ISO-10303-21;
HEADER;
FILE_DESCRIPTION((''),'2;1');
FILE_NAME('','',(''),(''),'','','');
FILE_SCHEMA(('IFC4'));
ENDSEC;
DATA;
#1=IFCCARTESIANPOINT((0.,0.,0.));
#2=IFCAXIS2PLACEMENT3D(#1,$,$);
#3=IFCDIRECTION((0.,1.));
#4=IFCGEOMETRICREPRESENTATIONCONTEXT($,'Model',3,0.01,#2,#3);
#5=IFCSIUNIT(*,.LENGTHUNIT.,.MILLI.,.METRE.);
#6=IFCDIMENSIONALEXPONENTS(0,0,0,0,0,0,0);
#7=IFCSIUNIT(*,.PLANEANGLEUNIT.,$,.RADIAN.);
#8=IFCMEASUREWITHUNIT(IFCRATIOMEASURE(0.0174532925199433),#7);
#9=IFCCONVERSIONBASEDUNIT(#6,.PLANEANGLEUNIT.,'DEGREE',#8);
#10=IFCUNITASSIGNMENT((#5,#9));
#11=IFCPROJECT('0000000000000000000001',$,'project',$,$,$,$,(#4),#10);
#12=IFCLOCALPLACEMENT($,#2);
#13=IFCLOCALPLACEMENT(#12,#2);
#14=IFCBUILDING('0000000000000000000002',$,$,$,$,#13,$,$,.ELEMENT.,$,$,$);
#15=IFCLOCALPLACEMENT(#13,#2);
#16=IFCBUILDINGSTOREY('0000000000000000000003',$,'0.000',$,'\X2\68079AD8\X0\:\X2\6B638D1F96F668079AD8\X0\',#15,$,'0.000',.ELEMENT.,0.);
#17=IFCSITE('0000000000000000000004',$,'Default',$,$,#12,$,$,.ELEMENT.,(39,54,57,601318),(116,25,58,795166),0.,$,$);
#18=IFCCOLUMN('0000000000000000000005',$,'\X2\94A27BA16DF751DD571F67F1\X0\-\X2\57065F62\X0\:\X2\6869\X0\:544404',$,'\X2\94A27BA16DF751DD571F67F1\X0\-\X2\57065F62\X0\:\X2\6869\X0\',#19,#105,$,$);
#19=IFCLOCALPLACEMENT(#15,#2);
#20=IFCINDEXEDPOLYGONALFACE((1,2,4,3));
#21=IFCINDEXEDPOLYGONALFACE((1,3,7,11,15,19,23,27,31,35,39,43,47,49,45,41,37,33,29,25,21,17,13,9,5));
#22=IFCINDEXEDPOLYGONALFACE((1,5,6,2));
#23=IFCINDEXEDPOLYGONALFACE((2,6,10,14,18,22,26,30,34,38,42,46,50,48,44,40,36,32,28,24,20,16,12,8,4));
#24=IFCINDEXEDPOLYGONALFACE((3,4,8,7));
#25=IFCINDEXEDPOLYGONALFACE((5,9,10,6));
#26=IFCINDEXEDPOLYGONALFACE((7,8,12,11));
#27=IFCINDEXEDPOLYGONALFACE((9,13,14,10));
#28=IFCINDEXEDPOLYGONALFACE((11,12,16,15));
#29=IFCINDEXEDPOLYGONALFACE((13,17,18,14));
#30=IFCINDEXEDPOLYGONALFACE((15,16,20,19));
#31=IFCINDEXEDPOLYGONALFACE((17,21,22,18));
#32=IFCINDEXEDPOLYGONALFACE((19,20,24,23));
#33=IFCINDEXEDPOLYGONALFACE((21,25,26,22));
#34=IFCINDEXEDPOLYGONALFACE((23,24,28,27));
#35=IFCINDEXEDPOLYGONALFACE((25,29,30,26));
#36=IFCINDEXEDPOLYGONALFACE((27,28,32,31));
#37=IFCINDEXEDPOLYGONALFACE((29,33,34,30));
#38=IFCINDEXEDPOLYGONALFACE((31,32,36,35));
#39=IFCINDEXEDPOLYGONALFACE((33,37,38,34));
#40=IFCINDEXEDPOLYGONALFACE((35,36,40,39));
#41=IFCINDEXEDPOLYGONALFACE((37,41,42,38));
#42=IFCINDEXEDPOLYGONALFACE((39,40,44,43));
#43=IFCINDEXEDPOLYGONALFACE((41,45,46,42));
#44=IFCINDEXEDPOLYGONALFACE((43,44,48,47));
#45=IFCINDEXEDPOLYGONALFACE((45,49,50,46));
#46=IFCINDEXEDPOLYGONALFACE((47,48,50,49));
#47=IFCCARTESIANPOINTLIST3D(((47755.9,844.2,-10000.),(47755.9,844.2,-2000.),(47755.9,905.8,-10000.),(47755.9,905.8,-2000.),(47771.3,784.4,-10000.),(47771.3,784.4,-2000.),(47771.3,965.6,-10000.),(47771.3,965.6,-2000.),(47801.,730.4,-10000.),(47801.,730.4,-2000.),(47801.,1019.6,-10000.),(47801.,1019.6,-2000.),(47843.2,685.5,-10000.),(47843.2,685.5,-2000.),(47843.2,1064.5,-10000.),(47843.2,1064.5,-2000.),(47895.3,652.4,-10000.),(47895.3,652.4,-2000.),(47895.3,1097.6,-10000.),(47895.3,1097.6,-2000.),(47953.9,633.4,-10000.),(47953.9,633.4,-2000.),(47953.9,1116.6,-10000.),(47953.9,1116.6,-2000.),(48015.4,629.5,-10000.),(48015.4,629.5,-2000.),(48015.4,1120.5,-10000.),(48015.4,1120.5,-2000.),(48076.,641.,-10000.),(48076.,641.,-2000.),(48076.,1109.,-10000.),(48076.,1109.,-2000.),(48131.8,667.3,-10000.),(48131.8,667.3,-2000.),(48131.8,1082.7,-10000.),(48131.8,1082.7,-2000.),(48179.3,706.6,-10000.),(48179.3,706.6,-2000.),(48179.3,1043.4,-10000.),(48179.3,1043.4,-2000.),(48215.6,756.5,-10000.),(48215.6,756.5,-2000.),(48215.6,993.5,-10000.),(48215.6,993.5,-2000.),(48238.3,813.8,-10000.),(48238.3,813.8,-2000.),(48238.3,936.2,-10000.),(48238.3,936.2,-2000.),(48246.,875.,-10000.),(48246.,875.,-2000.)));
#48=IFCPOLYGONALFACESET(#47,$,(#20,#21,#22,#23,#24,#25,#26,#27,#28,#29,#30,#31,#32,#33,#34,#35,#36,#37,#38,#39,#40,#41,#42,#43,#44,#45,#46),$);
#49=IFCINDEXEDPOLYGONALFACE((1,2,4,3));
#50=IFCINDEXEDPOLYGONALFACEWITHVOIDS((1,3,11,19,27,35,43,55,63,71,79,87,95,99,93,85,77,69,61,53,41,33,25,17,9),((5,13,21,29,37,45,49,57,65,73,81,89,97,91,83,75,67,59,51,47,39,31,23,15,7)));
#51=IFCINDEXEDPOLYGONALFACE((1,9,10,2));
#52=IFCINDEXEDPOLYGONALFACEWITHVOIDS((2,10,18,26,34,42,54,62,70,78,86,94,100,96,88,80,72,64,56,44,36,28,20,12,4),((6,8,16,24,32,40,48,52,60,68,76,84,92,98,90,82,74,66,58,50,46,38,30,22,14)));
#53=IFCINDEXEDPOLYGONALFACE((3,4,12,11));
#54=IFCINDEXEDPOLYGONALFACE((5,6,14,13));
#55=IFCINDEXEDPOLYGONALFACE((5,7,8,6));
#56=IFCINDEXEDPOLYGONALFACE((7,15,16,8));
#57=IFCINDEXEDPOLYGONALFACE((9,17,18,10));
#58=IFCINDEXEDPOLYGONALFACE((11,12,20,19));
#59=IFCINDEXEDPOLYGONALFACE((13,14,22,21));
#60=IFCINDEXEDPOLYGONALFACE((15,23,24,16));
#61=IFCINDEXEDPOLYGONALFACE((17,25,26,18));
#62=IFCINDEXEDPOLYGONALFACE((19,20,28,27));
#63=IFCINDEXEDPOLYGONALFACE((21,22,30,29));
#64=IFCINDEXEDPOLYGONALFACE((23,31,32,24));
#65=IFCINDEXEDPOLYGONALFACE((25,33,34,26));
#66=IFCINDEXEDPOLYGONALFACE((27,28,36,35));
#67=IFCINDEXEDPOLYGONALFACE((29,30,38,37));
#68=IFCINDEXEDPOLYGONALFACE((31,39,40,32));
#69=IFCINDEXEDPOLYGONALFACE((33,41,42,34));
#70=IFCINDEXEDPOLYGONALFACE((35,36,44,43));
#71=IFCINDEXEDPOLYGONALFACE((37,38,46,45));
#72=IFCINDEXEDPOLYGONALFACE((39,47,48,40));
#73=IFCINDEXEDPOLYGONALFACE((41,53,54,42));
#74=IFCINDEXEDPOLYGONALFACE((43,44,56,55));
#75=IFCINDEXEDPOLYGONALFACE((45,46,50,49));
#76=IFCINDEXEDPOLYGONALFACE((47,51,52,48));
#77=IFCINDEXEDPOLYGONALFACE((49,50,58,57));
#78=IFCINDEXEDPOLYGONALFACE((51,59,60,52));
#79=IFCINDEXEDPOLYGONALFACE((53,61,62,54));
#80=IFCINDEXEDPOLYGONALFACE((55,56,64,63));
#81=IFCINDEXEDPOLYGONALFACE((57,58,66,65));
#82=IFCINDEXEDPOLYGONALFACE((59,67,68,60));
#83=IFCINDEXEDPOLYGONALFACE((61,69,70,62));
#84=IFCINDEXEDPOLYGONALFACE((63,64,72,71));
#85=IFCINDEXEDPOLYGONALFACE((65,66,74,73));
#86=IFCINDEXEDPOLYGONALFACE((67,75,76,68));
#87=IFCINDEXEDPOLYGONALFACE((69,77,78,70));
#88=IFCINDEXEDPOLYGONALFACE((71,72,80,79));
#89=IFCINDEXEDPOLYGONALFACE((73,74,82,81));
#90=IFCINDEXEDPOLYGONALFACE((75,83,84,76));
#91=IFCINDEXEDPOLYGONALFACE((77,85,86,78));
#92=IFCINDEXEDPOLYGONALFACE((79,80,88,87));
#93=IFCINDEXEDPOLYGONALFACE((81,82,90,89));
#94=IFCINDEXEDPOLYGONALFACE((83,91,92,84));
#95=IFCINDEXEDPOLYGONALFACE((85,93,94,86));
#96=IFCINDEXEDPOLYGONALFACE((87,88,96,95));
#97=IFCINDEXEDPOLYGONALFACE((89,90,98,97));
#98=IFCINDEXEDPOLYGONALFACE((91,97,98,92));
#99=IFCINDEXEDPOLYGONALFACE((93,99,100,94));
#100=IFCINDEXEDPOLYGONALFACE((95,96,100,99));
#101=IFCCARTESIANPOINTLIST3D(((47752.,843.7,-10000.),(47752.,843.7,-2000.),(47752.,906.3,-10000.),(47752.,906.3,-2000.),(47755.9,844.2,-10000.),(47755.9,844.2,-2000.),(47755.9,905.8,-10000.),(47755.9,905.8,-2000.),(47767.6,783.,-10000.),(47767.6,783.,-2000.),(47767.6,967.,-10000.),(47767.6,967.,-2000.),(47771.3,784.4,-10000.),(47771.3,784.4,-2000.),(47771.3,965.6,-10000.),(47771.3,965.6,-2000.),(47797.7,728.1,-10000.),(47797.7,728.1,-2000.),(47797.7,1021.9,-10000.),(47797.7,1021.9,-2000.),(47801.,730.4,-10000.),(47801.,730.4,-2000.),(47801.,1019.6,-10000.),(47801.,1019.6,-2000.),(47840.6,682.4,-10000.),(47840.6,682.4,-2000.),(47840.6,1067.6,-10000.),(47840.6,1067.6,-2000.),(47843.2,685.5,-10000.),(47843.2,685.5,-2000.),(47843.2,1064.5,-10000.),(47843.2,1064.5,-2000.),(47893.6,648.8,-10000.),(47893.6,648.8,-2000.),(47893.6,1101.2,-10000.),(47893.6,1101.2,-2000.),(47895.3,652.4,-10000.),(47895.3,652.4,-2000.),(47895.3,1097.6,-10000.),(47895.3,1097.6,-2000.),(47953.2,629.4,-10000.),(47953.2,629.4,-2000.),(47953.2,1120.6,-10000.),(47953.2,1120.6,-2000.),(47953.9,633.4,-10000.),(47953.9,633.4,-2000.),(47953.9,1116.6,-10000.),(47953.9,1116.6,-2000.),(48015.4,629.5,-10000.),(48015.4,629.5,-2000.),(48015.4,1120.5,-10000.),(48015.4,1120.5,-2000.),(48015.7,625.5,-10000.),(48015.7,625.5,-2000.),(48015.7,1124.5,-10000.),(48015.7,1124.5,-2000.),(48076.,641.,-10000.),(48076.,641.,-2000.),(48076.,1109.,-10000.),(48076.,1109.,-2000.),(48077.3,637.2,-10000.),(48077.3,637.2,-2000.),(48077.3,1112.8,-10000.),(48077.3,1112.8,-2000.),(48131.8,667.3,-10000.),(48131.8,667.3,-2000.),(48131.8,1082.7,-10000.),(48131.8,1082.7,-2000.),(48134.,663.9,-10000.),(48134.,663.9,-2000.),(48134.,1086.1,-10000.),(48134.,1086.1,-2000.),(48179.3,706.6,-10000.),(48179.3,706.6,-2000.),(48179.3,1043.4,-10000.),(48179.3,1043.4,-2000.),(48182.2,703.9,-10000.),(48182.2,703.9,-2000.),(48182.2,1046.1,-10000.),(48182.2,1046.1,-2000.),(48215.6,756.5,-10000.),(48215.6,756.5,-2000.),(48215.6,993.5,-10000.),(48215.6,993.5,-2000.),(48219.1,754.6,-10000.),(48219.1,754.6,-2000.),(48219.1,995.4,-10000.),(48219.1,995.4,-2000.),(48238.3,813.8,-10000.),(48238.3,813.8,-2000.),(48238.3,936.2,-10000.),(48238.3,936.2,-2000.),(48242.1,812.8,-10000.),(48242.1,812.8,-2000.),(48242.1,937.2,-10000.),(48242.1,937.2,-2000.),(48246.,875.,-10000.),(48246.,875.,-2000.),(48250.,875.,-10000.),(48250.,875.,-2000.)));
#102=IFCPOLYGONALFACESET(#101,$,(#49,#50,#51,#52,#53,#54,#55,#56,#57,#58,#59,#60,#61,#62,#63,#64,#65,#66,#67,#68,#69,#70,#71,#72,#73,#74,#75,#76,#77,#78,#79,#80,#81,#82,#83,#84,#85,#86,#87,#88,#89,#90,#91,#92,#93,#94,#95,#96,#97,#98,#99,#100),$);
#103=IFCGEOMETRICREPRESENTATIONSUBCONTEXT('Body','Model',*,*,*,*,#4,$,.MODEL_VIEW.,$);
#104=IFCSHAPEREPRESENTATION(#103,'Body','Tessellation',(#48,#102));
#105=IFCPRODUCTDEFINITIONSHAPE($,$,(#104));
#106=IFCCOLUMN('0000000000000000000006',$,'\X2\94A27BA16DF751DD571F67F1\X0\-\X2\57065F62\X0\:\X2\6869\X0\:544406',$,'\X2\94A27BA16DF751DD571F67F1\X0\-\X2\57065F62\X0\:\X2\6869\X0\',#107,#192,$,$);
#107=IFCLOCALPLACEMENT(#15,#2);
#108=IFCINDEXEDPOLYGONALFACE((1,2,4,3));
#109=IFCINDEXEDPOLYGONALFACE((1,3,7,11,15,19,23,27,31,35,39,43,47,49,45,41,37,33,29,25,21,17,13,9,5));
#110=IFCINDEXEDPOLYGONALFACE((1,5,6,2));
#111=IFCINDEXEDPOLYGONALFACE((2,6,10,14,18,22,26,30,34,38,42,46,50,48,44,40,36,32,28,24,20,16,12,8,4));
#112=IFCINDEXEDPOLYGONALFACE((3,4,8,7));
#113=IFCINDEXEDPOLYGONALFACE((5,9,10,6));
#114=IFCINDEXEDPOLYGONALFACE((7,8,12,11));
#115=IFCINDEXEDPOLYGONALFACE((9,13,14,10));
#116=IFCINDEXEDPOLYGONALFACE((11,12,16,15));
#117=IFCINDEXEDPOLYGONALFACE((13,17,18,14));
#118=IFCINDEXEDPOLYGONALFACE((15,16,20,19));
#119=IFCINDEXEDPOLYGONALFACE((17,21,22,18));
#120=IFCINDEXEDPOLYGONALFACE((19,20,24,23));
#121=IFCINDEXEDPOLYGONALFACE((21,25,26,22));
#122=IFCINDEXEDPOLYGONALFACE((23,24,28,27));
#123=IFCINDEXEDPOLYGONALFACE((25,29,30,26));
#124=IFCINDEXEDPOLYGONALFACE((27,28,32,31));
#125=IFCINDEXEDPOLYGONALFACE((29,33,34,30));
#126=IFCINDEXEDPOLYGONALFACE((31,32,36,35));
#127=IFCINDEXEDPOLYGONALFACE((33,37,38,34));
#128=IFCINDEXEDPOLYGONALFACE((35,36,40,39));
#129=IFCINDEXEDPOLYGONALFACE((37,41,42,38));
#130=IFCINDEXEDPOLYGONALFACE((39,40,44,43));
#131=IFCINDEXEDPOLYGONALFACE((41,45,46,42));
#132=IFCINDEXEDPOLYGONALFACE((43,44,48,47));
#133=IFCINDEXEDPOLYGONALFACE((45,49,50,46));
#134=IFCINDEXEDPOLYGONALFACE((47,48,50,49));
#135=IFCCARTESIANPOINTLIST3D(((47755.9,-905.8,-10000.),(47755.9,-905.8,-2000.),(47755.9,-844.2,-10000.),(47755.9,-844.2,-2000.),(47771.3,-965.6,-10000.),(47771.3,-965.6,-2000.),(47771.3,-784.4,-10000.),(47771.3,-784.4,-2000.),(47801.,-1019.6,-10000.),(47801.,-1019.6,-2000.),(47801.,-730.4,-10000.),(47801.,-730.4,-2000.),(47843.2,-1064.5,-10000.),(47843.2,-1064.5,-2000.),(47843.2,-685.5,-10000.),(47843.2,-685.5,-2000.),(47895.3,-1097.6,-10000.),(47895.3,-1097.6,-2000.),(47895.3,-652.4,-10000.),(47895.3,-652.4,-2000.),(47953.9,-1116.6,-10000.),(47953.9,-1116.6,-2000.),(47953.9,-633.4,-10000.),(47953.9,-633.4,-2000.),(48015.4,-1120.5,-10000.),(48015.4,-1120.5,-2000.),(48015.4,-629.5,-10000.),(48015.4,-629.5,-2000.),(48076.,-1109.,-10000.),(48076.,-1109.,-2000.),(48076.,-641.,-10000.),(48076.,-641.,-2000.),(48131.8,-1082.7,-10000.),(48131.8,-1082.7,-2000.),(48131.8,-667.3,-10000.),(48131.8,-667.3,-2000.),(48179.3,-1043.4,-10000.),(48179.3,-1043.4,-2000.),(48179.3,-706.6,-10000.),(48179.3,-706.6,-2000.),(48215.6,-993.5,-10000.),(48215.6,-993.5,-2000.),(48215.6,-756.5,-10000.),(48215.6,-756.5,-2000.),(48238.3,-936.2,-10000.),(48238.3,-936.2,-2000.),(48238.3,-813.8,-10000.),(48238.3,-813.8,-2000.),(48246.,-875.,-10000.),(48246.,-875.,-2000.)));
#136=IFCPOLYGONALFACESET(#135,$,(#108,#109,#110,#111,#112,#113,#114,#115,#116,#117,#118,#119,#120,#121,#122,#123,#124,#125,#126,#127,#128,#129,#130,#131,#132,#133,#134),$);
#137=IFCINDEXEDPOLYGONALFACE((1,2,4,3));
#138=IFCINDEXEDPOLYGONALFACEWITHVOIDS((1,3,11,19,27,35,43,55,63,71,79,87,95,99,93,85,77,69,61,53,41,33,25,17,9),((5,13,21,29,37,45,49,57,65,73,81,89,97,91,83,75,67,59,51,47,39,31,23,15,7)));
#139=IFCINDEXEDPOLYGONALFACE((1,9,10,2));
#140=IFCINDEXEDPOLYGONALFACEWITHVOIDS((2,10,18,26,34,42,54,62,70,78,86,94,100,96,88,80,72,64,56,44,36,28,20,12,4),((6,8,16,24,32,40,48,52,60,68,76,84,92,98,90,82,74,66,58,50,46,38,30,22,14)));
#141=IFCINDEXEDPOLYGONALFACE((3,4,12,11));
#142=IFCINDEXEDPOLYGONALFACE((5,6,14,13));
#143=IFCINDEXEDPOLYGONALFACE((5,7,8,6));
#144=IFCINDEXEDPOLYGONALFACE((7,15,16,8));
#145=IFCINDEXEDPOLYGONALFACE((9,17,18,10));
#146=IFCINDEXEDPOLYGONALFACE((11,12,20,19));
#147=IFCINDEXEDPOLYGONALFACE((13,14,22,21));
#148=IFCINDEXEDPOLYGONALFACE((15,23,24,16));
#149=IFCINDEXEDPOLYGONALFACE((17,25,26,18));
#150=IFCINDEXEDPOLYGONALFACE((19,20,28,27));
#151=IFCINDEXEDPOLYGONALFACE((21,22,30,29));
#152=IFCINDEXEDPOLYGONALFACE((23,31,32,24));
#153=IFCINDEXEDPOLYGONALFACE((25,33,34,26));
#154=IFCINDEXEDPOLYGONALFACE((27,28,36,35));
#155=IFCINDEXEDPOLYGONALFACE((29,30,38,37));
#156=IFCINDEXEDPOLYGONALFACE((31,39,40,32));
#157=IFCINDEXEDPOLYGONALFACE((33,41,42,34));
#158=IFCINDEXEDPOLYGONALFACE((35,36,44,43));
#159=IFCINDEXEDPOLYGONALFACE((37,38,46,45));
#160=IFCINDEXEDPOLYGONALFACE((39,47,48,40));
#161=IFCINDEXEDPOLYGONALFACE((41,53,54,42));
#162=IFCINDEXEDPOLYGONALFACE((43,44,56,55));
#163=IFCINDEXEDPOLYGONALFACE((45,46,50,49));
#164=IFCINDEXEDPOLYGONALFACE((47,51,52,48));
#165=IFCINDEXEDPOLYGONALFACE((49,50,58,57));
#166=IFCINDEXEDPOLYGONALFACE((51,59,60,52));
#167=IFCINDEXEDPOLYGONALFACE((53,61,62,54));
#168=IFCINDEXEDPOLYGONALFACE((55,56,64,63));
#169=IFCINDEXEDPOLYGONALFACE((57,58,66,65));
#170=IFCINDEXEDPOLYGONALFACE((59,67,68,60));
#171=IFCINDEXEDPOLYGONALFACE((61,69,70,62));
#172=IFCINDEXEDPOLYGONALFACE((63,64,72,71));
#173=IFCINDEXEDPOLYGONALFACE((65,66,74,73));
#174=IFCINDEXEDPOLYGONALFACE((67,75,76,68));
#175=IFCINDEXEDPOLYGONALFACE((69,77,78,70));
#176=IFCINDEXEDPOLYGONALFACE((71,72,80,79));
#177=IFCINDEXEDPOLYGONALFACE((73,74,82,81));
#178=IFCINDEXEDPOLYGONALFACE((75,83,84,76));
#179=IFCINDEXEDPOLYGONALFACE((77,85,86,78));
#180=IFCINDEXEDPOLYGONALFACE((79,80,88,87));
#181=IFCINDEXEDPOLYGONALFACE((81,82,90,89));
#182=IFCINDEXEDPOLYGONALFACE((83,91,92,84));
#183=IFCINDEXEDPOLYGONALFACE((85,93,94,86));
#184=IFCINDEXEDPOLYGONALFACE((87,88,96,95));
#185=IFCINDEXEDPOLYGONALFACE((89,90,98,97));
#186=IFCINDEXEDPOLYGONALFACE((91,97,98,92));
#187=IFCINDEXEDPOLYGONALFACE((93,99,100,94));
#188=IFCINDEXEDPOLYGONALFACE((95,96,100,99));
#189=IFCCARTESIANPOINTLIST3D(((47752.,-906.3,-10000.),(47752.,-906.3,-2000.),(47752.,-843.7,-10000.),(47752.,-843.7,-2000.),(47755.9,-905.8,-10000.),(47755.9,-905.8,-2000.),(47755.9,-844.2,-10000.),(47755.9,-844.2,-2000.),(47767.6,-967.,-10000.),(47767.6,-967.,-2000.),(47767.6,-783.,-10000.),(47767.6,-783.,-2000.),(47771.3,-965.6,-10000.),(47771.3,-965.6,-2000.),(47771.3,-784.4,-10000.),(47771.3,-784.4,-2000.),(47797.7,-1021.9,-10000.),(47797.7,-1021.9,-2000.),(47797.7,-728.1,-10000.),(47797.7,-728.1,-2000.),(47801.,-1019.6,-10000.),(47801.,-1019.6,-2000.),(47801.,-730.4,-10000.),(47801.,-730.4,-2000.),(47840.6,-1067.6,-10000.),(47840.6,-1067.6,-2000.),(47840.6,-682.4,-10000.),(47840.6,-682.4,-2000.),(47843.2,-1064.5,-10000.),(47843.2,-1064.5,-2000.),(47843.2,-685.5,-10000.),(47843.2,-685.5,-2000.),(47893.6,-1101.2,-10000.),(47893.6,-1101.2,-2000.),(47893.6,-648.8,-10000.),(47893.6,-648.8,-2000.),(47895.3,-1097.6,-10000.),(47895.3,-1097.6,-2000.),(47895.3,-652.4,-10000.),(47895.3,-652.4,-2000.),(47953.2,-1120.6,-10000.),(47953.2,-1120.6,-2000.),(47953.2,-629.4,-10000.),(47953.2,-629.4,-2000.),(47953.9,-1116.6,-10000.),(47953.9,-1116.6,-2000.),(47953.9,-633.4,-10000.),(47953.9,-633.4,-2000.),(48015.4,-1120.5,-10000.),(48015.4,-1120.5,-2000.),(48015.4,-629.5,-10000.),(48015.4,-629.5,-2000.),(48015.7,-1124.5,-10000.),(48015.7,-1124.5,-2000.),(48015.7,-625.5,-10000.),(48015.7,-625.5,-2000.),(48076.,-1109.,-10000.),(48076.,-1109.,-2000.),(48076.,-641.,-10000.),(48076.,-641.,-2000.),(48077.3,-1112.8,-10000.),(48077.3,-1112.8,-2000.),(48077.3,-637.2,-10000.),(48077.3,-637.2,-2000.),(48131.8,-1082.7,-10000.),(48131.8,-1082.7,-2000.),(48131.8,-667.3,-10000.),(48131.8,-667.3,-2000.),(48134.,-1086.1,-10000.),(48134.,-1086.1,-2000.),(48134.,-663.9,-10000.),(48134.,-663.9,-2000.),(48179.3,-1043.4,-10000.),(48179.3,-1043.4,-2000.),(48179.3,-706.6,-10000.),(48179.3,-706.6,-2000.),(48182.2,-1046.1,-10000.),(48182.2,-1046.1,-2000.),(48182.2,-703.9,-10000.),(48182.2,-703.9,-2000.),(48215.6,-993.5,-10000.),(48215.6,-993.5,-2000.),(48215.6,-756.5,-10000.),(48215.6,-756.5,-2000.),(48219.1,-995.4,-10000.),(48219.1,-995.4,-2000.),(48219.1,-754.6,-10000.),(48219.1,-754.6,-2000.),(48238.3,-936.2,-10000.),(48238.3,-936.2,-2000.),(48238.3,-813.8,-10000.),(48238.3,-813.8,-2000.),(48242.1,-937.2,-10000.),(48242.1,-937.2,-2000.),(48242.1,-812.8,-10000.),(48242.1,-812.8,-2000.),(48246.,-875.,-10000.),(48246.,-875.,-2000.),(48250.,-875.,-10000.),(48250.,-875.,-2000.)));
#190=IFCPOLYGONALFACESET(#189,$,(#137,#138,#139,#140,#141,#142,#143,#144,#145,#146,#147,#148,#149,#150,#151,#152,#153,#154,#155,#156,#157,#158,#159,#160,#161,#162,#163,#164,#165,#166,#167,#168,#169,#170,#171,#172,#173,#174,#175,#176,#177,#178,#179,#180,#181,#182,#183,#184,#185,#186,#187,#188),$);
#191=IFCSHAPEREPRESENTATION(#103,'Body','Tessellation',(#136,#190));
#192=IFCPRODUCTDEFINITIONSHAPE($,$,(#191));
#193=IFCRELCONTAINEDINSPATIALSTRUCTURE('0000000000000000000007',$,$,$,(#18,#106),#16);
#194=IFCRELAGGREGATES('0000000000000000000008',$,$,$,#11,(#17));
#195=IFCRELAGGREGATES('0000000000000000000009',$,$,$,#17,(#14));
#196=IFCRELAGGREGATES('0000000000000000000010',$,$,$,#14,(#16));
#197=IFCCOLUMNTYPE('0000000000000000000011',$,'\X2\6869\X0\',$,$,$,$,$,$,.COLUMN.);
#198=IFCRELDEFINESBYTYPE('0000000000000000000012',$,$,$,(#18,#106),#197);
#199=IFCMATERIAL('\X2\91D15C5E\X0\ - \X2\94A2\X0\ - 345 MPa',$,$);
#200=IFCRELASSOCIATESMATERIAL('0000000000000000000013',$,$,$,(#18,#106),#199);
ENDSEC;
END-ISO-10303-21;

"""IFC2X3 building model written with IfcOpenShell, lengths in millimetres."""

from ifc_helpers import new_model, entity, si_unit, converted_unit, direction, frame, frame_2d, origin, place, context, subcontext, project, spatial, circle, hollow_circle, extrude, source, transform, mapped, material, type_object, type_shapes, element, save


model = new_model("IFC2X3")

# Units and contexts
model_context = context("Model", 3, precision=0.01, world=origin(), true_north=direction((0.0, 1.0)))
body_context = subcontext(model_context, "Body", "Model", "MODEL_VIEW")
ifc_project = project(units=[si_unit("LENGTHUNIT", "METRE", prefix="MILLI"), converted_unit("PLANEANGLEUNIT", "DEGREE", entity("IfcRatioMeasure", 0.0174532925199433), si_unit("PLANEANGLEUNIT", "RADIAN"), dimensions=[0, 0, 0, 0, 0, 0, 0])], contexts=[model_context])

# Site, building, storey
site_placement = place(None, origin())
site = spatial("IfcSite", under=ifc_project, at=site_placement, Name="Default", CompositionType="ELEMENT", RefLatitude=(39, 54, 57, 601318), RefLongitude=(116, 25, 58, 795166), RefElevation=0.0)
building_placement = place(site_placement, origin())
building = spatial("IfcBuilding", under=site, at=building_placement, CompositionType="ELEMENT")
storey_placement = place(building_placement, origin())
storey = spatial("IfcBuildingStorey", under=building, at=storey_placement, Name="0.000", ObjectType="标高:正负零标高", LongName="0.000", CompositionType="ELEMENT", Elevation=0.0)

# Columns
ifc_material_1 = material(Name="金属 - 钢 - 345 MPa")
column_type = type_object("IfcColumnType", Name="桩", PredefinedType="COLUMN")
shared_shape = source(origin(), body_context, "Body", "SweptSolid", [
    extrude(circle(Radius=246.0, at=frame_2d((0.0, 0.0), x_axis=(1.0, 0.0))), frame((0.0, 0.0, -10000.0)), (0.0, 0.0, 1.0), 8000.0),
    extrude(hollow_circle(Radius=250.0, WallThickness=4.0, at=frame_2d((0.0, 0.0), x_axis=(1.0, 0.0))), frame((0.0, 0.0, -10000.0)), (0.0, 0.0, 1.0), 8000.0),
])
type_shapes(column_type, [shared_shape])
for number, where, name in (
    (1, (48000.0, 875.0, 0.0), "钢管混凝土柱-圆形:桩:544404"),
    (2, (48000.0, -875.0, 0.0), "钢管混凝土柱-圆形:桩:544406"),
):
    element("IfcColumn", number, at=place(storey_placement, frame(where)), inside=storey, type_object=column_type, material=ifc_material_1, Name=name, ObjectType="钢管混凝土柱-圆形:桩", context=body_context, shape_type="MappedRepresentation", body=[
        mapped(shared_shape, transform((0.0, 0.0, 0.0), scale=1.0)),
    ])

save(model, "model.ifc")
